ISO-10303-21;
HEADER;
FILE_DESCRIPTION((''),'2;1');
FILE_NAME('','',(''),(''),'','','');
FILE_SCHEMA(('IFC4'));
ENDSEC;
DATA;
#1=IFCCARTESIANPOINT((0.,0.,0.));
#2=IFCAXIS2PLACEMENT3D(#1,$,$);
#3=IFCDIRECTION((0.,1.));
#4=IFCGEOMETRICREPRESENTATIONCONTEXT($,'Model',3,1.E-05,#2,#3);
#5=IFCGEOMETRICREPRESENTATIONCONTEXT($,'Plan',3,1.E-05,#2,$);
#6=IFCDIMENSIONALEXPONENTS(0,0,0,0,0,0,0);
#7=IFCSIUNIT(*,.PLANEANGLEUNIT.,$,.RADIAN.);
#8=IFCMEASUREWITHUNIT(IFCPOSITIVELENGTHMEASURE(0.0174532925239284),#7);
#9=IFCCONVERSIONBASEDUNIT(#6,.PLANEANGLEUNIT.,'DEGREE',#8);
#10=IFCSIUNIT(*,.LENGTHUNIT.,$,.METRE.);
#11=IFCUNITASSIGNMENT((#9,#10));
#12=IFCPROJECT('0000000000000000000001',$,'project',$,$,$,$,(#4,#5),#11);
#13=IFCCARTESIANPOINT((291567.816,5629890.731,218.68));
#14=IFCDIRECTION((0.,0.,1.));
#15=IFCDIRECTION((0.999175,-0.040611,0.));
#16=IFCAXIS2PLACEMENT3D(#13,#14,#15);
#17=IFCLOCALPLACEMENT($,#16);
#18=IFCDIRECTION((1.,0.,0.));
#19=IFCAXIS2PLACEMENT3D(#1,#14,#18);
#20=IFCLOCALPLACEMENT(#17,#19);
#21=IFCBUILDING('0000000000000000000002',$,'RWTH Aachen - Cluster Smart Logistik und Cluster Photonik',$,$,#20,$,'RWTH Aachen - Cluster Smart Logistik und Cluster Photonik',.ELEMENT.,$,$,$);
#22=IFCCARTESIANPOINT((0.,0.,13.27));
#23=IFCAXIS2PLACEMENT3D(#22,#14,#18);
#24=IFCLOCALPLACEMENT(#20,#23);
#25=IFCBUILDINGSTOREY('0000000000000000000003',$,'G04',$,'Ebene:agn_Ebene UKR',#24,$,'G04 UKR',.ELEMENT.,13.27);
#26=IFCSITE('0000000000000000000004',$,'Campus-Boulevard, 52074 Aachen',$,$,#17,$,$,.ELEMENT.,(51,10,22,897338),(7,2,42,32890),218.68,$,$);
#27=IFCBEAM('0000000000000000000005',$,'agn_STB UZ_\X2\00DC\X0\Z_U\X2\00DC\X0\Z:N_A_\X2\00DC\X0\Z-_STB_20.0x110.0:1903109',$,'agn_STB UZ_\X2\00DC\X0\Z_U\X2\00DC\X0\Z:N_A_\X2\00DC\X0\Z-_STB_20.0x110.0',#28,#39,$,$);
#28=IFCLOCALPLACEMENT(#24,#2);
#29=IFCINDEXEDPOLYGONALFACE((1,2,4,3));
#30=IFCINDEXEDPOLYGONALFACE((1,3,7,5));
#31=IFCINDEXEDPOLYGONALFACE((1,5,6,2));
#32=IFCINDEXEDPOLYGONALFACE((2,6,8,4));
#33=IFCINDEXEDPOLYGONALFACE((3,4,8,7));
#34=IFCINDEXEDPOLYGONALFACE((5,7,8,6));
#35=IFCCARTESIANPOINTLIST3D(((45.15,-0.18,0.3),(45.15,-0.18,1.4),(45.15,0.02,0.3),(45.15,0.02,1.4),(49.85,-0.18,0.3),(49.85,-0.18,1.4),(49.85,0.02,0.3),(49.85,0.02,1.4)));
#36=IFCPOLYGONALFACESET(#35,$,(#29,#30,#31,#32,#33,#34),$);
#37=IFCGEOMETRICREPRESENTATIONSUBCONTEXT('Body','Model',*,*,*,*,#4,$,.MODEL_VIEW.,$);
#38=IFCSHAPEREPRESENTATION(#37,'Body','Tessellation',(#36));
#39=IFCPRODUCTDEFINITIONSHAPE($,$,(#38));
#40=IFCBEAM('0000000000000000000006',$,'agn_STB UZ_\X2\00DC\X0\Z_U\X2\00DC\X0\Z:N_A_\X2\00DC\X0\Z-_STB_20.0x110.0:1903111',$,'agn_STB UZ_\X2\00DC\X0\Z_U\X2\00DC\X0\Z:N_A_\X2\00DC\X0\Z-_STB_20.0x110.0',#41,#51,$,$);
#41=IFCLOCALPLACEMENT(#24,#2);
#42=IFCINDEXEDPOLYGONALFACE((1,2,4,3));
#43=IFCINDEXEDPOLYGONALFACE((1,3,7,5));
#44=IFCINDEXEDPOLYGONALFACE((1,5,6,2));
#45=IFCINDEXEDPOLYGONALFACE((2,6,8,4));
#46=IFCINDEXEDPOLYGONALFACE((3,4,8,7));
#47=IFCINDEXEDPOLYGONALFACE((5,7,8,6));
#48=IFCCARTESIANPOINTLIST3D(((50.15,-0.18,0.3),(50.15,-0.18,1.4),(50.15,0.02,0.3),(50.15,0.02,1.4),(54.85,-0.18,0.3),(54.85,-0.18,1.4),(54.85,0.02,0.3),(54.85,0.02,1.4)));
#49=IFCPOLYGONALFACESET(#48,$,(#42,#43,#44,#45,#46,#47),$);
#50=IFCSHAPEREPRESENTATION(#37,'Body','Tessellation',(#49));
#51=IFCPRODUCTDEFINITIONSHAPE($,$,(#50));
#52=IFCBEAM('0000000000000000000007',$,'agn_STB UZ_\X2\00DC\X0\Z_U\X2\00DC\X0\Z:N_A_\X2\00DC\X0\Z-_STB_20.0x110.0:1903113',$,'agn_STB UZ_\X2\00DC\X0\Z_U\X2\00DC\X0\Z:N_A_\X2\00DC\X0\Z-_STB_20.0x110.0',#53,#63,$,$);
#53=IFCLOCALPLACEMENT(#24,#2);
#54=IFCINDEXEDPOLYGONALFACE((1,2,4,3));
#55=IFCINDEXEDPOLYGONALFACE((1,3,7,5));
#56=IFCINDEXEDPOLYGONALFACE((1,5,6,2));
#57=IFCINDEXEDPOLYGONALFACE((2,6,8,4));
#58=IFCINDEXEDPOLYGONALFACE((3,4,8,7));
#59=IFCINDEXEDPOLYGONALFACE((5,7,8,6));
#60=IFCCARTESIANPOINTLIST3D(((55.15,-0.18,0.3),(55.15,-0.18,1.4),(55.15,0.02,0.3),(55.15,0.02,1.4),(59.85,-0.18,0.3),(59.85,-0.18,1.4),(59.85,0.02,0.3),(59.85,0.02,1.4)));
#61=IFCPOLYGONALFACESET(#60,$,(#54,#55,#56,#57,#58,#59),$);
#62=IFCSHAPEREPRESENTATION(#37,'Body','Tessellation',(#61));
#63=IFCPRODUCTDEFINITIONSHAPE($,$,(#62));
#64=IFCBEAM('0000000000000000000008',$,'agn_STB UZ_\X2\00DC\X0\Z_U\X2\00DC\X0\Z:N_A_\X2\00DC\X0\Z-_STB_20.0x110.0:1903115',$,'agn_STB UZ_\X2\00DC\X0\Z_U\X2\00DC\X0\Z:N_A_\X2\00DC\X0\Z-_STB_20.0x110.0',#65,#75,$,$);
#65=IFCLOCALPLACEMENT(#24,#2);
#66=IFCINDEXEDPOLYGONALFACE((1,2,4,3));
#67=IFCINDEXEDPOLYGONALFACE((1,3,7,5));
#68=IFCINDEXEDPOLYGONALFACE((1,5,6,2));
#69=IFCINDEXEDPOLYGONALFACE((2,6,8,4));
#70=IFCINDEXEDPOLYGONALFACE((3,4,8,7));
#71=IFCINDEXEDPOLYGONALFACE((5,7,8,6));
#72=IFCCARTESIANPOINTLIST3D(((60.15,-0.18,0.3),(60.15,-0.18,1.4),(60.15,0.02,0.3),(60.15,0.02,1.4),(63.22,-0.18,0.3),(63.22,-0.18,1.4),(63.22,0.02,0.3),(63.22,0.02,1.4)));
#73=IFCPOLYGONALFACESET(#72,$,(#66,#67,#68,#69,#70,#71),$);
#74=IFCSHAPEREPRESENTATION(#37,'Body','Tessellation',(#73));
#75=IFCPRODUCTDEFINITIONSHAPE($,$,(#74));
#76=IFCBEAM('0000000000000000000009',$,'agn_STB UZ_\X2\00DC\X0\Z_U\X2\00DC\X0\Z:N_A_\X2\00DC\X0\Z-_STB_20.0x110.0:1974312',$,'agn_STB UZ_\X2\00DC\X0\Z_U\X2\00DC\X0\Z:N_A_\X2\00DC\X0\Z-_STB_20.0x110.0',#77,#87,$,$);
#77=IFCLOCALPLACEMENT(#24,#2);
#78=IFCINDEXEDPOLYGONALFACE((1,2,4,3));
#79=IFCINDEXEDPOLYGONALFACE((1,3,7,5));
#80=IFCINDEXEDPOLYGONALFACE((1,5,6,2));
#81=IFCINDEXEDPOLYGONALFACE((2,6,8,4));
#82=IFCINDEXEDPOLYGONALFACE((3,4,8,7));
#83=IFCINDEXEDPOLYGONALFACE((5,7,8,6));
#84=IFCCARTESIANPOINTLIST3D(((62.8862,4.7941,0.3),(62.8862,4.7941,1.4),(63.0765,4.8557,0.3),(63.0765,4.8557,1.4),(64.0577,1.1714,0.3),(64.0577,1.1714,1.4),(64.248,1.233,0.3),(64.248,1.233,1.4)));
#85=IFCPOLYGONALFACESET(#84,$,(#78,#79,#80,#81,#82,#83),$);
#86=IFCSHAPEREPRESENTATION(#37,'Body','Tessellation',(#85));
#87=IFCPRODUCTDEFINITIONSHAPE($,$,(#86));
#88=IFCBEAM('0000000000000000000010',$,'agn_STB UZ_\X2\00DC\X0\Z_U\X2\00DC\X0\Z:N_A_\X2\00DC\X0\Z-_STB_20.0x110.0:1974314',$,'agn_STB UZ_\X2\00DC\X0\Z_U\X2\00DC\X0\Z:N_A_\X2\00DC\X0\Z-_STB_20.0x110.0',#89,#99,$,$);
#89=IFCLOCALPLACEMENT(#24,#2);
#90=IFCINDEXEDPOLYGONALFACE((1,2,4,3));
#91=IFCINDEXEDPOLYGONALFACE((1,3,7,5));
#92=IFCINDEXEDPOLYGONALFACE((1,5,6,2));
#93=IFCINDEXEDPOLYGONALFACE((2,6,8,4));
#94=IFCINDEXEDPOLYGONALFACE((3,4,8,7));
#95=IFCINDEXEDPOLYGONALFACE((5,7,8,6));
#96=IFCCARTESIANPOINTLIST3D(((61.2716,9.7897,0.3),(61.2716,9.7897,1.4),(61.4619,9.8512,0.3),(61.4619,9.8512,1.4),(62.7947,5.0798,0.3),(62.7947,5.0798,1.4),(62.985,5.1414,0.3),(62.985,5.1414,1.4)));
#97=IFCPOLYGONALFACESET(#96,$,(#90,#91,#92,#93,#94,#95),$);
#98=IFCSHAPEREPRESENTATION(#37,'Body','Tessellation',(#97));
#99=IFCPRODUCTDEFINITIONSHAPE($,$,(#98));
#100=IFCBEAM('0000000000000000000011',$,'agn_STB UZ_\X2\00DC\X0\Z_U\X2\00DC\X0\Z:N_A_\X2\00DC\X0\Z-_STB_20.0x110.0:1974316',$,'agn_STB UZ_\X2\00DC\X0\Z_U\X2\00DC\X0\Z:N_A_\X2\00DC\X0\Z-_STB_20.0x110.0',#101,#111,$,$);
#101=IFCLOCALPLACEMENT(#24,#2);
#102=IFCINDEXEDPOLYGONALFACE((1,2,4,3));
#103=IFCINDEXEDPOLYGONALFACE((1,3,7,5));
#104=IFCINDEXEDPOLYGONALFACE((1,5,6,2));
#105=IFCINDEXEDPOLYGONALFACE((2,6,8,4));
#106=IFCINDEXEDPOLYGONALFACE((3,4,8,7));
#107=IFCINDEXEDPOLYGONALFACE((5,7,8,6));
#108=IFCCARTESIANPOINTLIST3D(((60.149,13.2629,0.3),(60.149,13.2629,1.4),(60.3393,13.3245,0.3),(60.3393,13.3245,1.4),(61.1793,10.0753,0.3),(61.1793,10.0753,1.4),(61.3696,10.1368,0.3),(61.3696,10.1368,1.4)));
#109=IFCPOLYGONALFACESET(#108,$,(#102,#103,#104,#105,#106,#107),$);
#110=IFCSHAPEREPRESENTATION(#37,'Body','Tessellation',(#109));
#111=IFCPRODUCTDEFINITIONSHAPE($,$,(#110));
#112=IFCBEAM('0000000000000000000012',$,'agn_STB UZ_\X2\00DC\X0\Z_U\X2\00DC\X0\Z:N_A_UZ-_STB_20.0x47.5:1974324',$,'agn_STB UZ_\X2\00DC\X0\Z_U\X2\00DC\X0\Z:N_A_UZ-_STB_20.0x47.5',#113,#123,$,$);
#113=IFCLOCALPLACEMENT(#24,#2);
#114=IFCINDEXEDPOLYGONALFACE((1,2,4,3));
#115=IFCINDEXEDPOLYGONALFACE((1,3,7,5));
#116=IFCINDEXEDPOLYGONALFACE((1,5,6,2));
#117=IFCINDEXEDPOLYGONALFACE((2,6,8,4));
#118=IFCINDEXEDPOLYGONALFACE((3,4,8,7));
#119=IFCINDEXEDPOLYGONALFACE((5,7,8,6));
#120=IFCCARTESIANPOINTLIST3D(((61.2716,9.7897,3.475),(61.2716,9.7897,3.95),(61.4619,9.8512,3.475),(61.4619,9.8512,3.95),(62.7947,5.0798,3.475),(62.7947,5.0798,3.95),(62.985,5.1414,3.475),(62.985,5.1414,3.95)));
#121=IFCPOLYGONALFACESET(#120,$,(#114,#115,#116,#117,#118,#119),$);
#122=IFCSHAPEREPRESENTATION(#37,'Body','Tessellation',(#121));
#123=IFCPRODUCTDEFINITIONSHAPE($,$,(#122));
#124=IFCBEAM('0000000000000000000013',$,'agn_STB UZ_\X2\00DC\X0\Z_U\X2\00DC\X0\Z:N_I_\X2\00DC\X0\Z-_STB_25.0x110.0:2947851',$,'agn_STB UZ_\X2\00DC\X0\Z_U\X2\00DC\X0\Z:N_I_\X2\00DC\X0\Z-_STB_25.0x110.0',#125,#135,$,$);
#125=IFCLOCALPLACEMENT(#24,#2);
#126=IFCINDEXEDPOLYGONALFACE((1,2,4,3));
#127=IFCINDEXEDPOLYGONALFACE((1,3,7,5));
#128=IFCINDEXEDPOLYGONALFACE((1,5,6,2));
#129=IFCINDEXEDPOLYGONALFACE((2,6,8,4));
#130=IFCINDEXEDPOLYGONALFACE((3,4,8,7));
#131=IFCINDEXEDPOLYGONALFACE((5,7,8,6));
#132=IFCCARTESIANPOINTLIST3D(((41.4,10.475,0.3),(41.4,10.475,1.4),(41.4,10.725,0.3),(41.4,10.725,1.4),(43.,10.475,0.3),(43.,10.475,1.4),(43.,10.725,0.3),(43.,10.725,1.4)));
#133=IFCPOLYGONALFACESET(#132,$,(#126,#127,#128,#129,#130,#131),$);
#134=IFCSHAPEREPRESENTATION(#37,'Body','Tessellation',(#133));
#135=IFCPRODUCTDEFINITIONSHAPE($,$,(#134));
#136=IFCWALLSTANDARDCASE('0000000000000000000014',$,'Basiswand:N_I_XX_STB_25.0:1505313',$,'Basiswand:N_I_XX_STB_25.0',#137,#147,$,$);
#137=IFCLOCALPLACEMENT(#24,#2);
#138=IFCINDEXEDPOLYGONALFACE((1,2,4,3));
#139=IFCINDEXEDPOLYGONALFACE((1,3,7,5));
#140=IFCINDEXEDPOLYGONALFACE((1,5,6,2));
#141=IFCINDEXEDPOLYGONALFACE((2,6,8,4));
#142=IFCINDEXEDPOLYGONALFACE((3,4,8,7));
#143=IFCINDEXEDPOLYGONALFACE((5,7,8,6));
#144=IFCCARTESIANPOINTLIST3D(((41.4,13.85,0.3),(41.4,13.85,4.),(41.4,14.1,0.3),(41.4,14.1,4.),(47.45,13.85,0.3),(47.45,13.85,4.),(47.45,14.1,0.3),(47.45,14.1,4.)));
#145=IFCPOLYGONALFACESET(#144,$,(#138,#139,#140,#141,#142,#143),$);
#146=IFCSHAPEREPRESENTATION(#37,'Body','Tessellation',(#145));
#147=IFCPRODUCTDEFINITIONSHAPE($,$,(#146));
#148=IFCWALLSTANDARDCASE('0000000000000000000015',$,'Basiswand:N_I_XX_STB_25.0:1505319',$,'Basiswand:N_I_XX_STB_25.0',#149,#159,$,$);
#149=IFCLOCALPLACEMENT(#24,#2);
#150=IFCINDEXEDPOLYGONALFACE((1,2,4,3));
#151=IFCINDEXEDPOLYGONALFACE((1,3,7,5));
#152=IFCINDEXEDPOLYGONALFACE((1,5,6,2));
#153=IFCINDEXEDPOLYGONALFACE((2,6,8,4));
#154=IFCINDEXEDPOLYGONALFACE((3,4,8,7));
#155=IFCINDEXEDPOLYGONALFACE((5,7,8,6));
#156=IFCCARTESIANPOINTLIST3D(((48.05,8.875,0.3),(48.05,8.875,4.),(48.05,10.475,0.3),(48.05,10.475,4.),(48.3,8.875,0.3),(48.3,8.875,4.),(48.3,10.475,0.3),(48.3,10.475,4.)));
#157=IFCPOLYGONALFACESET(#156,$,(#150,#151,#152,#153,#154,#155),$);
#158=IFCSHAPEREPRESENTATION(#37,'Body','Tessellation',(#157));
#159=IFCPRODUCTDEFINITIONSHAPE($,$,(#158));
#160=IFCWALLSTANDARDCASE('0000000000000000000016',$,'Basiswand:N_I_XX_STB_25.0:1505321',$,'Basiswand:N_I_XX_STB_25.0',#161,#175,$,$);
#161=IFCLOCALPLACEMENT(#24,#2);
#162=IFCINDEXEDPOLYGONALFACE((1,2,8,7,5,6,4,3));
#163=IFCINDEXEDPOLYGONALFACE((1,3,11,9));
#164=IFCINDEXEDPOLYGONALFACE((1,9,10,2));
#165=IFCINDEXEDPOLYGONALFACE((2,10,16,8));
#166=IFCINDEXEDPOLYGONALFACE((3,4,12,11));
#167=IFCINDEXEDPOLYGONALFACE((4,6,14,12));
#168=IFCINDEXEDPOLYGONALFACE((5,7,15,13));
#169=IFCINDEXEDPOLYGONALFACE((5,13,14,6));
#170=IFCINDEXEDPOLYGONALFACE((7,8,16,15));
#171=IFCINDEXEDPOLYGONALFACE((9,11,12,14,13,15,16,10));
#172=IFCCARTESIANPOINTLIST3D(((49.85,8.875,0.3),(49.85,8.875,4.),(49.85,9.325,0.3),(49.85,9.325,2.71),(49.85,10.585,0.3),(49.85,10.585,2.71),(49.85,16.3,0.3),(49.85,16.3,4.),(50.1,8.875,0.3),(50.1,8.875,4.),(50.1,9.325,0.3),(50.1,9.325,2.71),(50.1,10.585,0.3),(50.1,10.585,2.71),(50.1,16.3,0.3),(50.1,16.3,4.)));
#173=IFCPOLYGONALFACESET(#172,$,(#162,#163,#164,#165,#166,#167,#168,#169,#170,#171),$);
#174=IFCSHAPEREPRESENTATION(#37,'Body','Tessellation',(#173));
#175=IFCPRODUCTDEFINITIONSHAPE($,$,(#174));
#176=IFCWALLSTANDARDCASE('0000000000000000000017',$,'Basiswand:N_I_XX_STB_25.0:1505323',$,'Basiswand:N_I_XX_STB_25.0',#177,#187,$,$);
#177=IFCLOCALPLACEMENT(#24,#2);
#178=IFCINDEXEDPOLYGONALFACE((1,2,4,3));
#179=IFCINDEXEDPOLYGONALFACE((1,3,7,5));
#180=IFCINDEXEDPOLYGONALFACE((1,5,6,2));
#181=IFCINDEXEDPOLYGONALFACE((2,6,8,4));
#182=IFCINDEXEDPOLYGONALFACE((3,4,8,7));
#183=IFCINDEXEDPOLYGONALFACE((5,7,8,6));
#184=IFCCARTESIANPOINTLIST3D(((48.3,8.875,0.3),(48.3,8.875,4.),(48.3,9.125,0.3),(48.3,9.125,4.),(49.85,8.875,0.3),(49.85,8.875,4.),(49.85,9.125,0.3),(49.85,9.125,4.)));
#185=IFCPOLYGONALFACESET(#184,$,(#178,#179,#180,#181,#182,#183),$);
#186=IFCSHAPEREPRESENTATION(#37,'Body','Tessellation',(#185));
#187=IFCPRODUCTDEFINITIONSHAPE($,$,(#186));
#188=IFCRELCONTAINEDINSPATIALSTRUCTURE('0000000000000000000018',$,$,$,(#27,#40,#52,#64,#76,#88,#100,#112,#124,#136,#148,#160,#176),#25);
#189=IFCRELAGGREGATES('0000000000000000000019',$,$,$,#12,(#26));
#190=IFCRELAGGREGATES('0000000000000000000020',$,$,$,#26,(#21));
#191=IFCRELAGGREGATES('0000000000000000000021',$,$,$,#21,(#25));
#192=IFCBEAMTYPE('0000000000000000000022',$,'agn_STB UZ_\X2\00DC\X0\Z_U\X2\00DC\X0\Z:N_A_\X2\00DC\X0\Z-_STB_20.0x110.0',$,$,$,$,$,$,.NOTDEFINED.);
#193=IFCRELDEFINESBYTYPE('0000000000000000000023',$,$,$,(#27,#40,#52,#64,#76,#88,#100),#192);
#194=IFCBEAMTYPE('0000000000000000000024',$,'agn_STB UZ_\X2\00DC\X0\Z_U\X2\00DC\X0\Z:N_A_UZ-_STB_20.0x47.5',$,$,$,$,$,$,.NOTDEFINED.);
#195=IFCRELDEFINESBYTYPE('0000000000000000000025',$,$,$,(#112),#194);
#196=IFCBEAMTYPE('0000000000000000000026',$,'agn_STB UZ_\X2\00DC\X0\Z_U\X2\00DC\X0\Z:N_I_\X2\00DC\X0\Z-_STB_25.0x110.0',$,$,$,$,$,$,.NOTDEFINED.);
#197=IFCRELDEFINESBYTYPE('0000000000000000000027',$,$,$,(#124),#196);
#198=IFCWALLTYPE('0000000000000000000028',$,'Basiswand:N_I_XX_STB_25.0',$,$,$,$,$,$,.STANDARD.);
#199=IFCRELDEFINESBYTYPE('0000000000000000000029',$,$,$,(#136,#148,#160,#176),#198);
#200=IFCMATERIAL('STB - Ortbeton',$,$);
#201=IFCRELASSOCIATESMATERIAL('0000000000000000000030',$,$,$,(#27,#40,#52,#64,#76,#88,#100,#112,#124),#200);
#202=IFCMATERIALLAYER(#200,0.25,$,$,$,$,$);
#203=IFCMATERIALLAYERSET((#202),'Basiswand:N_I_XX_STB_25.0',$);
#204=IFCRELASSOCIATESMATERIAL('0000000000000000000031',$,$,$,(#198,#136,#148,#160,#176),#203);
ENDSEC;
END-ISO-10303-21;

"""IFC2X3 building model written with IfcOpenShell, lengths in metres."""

from ifc_helpers import new_model, entity, si_unit, converted_unit, direction, frame, frame_2d, origin, origin_with_axes, place, context, subcontext, project, spatial, rectangle, extrude, material, layer, layer_set, layer_usage, type_object, element, save


model = new_model("IFC2X3")

# Units and contexts
model_context = context("Model", 3, precision=1e-05, world=origin(), true_north=direction((0.0, 1.0)))
plan_context = context("Plan", 3, precision=1e-05, world=origin())
body_context = subcontext(model_context, "Body", "Model", "MODEL_VIEW")
ifc_project = project(units=[converted_unit("PLANEANGLEUNIT", "DEGREE", entity("IfcPositiveLengthMeasure", 0.0174532925239284), si_unit("PLANEANGLEUNIT", "RADIAN"), dimensions=[0, 0, 0, 0, 0, 0, 0]), si_unit("LENGTHUNIT", "METRE")], contexts=[model_context, plan_context])

# Site, building, storey
site_placement = place(None, frame((291567.816, 5629890.731, 218.68), z_axis=(0.0, 0.0, 1.0), x_axis=(0.999175, -0.040611, 0.0)))
site = spatial("IfcSite", under=ifc_project, at=site_placement, Name="Campus-Boulevard, 52074 Aachen", CompositionType="ELEMENT", RefLatitude=(51, 10, 22, 897338), RefLongitude=(7, 2, 42, 32890), RefElevation=218.68)
building_placement = place(site_placement, origin_with_axes())
building = spatial("IfcBuilding", under=site, at=building_placement, Name="RWTH Aachen - Cluster Smart Logistik und Cluster Photonik", LongName="RWTH Aachen - Cluster Smart Logistik und Cluster Photonik", CompositionType="ELEMENT")
storey_placement = place(building_placement, frame((0.0, 0.0, 13.27), z_axis=(0.0, 0.0, 1.0), x_axis=(1.0, 0.0, 0.0)))
storey = spatial("IfcBuildingStorey", under=building, at=storey_placement, Name="G04", ObjectType="Ebene:agn_Ebene UKR", LongName="G04 UKR", CompositionType="ELEMENT", Elevation=13.27)

# Beams
ifc_material_1 = material(Name="STB - Ortbeton")
beam_type_1 = type_object("IfcBeamType", Name="agn_STB UZ_ÜZ_UÜZ:N_A_ÜZ-_STB_20.0x110.0", PredefinedType="NOTDEFINED")
for number, where, z_axis, x_axis, name in (
    (1, (45.15, -0.08, 0.3), (0.0, 0.0, 1.0), (1.0, 0.0, 0.0), "agn_STB UZ_ÜZ_UÜZ:N_A_ÜZ-_STB_20.0x110.0:1903109"),
    (2, (50.15, -0.08, 0.3), (0.0, 0.0, 1.0), (1.0, 0.0, 0.0), "agn_STB UZ_ÜZ_UÜZ:N_A_ÜZ-_STB_20.0x110.0:1903111"),
    (3, (55.15, -0.08, 0.3), (0.0, 0.0, 1.0), (1.0, 0.0, 0.0), "agn_STB UZ_ÜZ_UÜZ:N_A_ÜZ-_STB_20.0x110.0:1903113"),
):
    element("IfcBeam", number, at=place(storey_placement, frame(where, z_axis=z_axis, x_axis=x_axis)), inside=storey, type_object=beam_type_1, material=ifc_material_1, Name=name, ObjectType="agn_STB UZ_ÜZ_UÜZ:N_A_ÜZ-_STB_20.0x110.0", context=body_context, shape_type="SweptSolid", body=[
        extrude(rectangle(XDim=1.1, YDim=0.2, at=frame_2d((0.0, 0.0), x_axis=(1.0, 0.0))), frame((0.0, 0.0, 0.55), z_axis=(1.0, 0.0, 0.0), x_axis=(0.0, 0.0, -1.0)), (0.0, 0.0, 1.0), 4.7),
    ])
beam_1_placement = place(storey_placement, frame((60.15, -0.08, 0.3), z_axis=(0.0, 0.0, 1.0), x_axis=(1.0, 0.0, 0.0)))
element("IfcBeam", 4, at=beam_1_placement, inside=storey, type_object=beam_type_1, material=ifc_material_1, Name="agn_STB UZ_ÜZ_UÜZ:N_A_ÜZ-_STB_20.0x110.0:1903115", ObjectType="agn_STB UZ_ÜZ_UÜZ:N_A_ÜZ-_STB_20.0x110.0", context=body_context, shape_type="SweptSolid", body=[
    extrude(rectangle(XDim=1.1, YDim=0.2, at=frame_2d((0.0, 0.0), x_axis=(1.0, 0.0))), frame((0.0, 0.0, 0.55), z_axis=(1.0, 0.0, 0.0), x_axis=(0.0, 0.0, -1.0)), (0.0, 0.0, 1.0), 3.07),
])
beam_2_placement = place(storey_placement, frame((62.9812, 4.8253, 0.3), z_axis=(0.0, 0.0, 1.0), x_axis=(0.307689, -0.951487, 0.0)))
element("IfcBeam", 5, at=beam_2_placement, inside=storey, type_object=beam_type_1, material=ifc_material_1, Name="agn_STB UZ_ÜZ_UÜZ:N_A_ÜZ-_STB_20.0x110.0:1974312", ObjectType="agn_STB UZ_ÜZ_UÜZ:N_A_ÜZ-_STB_20.0x110.0", context=body_context, shape_type="SweptSolid", body=[
    extrude(rectangle(XDim=1.1, YDim=0.2, at=frame_2d((0.0, 0.0), x_axis=(1.0, 0.0))), frame((0.0004, 0.0, 0.55), z_axis=(1.0, 0.0, 0.0), x_axis=(0.0, 0.0, -1.0)), (0.0, 0.0, 1.0), 3.8074),
])
beam_3_placement = place(storey_placement, frame((61.3667, 9.8206, 0.3), z_axis=(0.0, 0.0, 1.0), x_axis=(0.307689, -0.951487, 0.0)))
element("IfcBeam", 6, at=beam_3_placement, inside=storey, type_object=beam_type_1, material=ifc_material_1, Name="agn_STB UZ_ÜZ_UÜZ:N_A_ÜZ-_STB_20.0x110.0:1974314", ObjectType="agn_STB UZ_ÜZ_UÜZ:N_A_ÜZ-_STB_20.0x110.0", context=body_context, shape_type="SweptSolid", body=[
    extrude(rectangle(XDim=1.1, YDim=0.2, at=frame_2d((0.0, 0.0), x_axis=(1.0, 0.0))), frame((0.0002, 0.0, 0.55), z_axis=(1.0, 0.0, 0.0), x_axis=(0.0, 0.0, -1.0)), (0.0, 0.0, 1.0), 4.95),
])
beam_4_placement = place(storey_placement, frame((60.2441, 13.294, 0.3), z_axis=(0.0, 0.0, 1.0), x_axis=(0.307544, -0.951534, 0.0)))
element("IfcBeam", 7, at=beam_4_placement, inside=storey, type_object=beam_type_1, material=ifc_material_1, Name="agn_STB UZ_ÜZ_UÜZ:N_A_ÜZ-_STB_20.0x110.0:1974316", ObjectType="agn_STB UZ_ÜZ_UÜZ:N_A_ÜZ-_STB_20.0x110.0", context=body_context, shape_type="SweptSolid", body=[
    extrude(rectangle(XDim=1.1, YDim=0.2, at=frame_2d((0.0, 0.0), x_axis=(1.0, 0.0))), frame((0.0003, 0.0, 0.55), z_axis=(1.0, 0.0, 0.0), x_axis=(0.0, 0.0, -1.0)), (0.0, 0.0, 1.0), 3.35),
])
beam_type_2 = type_object("IfcBeamType", Name="agn_STB UZ_ÜZ_UÜZ:N_A_UZ-_STB_20.0x47.5", PredefinedType="NOTDEFINED")
beam_5_placement = place(storey_placement, frame((61.3667, 9.8206, 0.3), z_axis=(0.0, 0.0, 1.0), x_axis=(0.307689, -0.951487, 0.0)))
element("IfcBeam", 8, at=beam_5_placement, inside=storey, type_object=beam_type_2, material=ifc_material_1, Name="agn_STB UZ_ÜZ_UÜZ:N_A_UZ-_STB_20.0x47.5:1974324", ObjectType="agn_STB UZ_ÜZ_UÜZ:N_A_UZ-_STB_20.0x47.5", context=body_context, shape_type="SweptSolid", body=[
    extrude(rectangle(XDim=0.475, YDim=0.2, at=frame_2d((0.0, 0.0), x_axis=(1.0, 0.0))), frame((0.0002, 0.0, 3.4125), z_axis=(1.0, 0.0, 0.0), x_axis=(0.0, 0.0, -1.0)), (0.0, 0.0, 1.0), 4.95),
])
beam_type_3 = type_object("IfcBeamType", Name="agn_STB UZ_ÜZ_UÜZ:N_I_ÜZ-_STB_25.0x110.0", PredefinedType="NOTDEFINED")
beam_6_placement = place(storey_placement, frame((43.1, 10.6, 0.3), z_axis=(0.0, 0.0, 1.0), x_axis=(-1.0, 0.0, 0.0)))
element("IfcBeam", 9, at=beam_6_placement, inside=storey, type_object=beam_type_3, material=ifc_material_1, Name="agn_STB UZ_ÜZ_UÜZ:N_I_ÜZ-_STB_25.0x110.0:2947851", ObjectType="agn_STB UZ_ÜZ_UÜZ:N_I_ÜZ-_STB_25.0x110.0", context=body_context, shape_type="SweptSolid", body=[
    extrude(rectangle(XDim=1.1, YDim=0.25, at=frame_2d((0.0, 0.0), x_axis=(1.0, 0.0))), frame((0.1, 0.0, 0.55), z_axis=(1.0, 0.0, 0.0), x_axis=(0.0, 0.0, -1.0)), (0.0, 0.0, 1.0), 1.6),
])

# Walls
ifc_layer_1 = layer(ifc_material_1, 0.25)
ifc_layer_set_1 = layer_set([ifc_layer_1], Name="Basiswand:N_I_XX_STB_25.0")
ifc_layer_usage_1 = layer_usage(ifc_layer_set_1, "AXIS2", "NEGATIVE", 0.125)
wall_type_1 = type_object("IfcWallType", Name="Basiswand:N_I_XX_STB_25.0", PredefinedType="STANDARD", material=ifc_layer_set_1)
wall_1_placement = place(storey_placement, frame((41.4, 13.975, 0.3), z_axis=(0.0, 0.0, 1.0), x_axis=(1.0, 0.0, 0.0)))
element("IfcWallStandardCase", 10, at=wall_1_placement, inside=storey, type_object=wall_type_1, material=ifc_layer_usage_1, Name="Basiswand:N_I_XX_STB_25.0:1505313", ObjectType="Basiswand:N_I_XX_STB_25.0", context=body_context, shape_type="SweptSolid", body=[
    extrude(rectangle(XDim=6.05, YDim=0.25, at=frame_2d((3.025, 0.0), x_axis=(-1.0, 0.0))), origin(), (0.0, 0.0, 1.0), 3.7),
])
ifc_layer_usage_2 = layer_usage(ifc_layer_set_1, "AXIS2", "NEGATIVE", 0.125)
wall_2_placement = place(storey_placement, frame((48.175, 8.875, 0.3), z_axis=(0.0, 0.0, 1.0), x_axis=(0.0, 1.0, 0.0)))
element("IfcWallStandardCase", 11, at=wall_2_placement, inside=storey, type_object=wall_type_1, material=ifc_layer_usage_2, Name="Basiswand:N_I_XX_STB_25.0:1505319", ObjectType="Basiswand:N_I_XX_STB_25.0", context=body_context, shape_type="SweptSolid", body=[
    extrude(rectangle(XDim=1.6, YDim=0.25, at=frame_2d((0.8, 0.0), x_axis=(-1.0, 0.0))), origin(), (0.0, 0.0, 1.0), 3.7),
])

# Wall, opening
ifc_layer_usage_3 = layer_usage(ifc_layer_set_1, "AXIS2", "NEGATIVE", 0.125)
wall_3_placement = place(storey_placement, frame((49.975, 8.875, 0.3), z_axis=(0.0, 0.0, 1.0), x_axis=(0.0, 1.0, 0.0)))
wall_3 = element("IfcWallStandardCase", 12, at=wall_3_placement, inside=storey, type_object=wall_type_1, material=ifc_layer_usage_3, Name="Basiswand:N_I_XX_STB_25.0:1505321", ObjectType="Basiswand:N_I_XX_STB_25.0", context=body_context, shape_type="SweptSolid", body=[
    extrude(rectangle(XDim=7.425, YDim=0.25, at=frame_2d((3.7125, 0.0), x_axis=(-1.0, 0.0))), origin(), (0.0, 0.0, 1.0), 3.7),
])
opening_placement = place(wall_3_placement, frame((0.45, -0.125, 0.0), z_axis=(0.0, 0.0, 1.0), x_axis=(1.0, 0.0, 0.0)))
element("IfcOpeningElement", 13, at=opening_placement, cuts=wall_3, ObjectType="Opening", context=body_context, shape_type="SweptSolid", body=[
    extrude(rectangle(XDim=2.41, YDim=1.26, at=frame_2d((1.205, 0.63), x_axis=(1.0, 0.0))), frame((0.0, 0.0, 0.0), z_axis=(0.0, 1.0, 0.0), x_axis=(0.0, 0.0, 1.0)), (0.0, 0.0, 1.0), 0.25),
])

# Wall
ifc_layer_usage_4 = layer_usage(ifc_layer_set_1, "AXIS2", "NEGATIVE", 0.125)
wall_4_placement = place(storey_placement, frame((48.3, 9.0, 0.3), z_axis=(0.0, 0.0, 1.0), x_axis=(1.0, 0.0, 0.0)))
element("IfcWallStandardCase", 14, at=wall_4_placement, inside=storey, type_object=wall_type_1, material=ifc_layer_usage_4, Name="Basiswand:N_I_XX_STB_25.0:1505323", ObjectType="Basiswand:N_I_XX_STB_25.0", context=body_context, shape_type="SweptSolid", body=[
    extrude(rectangle(XDim=1.55, YDim=0.25, at=frame_2d((0.775, 0.0), x_axis=(-1.0, 0.0))), origin(), (0.0, 0.0, 1.0), 3.7),
])

save(model, "model.ifc")
